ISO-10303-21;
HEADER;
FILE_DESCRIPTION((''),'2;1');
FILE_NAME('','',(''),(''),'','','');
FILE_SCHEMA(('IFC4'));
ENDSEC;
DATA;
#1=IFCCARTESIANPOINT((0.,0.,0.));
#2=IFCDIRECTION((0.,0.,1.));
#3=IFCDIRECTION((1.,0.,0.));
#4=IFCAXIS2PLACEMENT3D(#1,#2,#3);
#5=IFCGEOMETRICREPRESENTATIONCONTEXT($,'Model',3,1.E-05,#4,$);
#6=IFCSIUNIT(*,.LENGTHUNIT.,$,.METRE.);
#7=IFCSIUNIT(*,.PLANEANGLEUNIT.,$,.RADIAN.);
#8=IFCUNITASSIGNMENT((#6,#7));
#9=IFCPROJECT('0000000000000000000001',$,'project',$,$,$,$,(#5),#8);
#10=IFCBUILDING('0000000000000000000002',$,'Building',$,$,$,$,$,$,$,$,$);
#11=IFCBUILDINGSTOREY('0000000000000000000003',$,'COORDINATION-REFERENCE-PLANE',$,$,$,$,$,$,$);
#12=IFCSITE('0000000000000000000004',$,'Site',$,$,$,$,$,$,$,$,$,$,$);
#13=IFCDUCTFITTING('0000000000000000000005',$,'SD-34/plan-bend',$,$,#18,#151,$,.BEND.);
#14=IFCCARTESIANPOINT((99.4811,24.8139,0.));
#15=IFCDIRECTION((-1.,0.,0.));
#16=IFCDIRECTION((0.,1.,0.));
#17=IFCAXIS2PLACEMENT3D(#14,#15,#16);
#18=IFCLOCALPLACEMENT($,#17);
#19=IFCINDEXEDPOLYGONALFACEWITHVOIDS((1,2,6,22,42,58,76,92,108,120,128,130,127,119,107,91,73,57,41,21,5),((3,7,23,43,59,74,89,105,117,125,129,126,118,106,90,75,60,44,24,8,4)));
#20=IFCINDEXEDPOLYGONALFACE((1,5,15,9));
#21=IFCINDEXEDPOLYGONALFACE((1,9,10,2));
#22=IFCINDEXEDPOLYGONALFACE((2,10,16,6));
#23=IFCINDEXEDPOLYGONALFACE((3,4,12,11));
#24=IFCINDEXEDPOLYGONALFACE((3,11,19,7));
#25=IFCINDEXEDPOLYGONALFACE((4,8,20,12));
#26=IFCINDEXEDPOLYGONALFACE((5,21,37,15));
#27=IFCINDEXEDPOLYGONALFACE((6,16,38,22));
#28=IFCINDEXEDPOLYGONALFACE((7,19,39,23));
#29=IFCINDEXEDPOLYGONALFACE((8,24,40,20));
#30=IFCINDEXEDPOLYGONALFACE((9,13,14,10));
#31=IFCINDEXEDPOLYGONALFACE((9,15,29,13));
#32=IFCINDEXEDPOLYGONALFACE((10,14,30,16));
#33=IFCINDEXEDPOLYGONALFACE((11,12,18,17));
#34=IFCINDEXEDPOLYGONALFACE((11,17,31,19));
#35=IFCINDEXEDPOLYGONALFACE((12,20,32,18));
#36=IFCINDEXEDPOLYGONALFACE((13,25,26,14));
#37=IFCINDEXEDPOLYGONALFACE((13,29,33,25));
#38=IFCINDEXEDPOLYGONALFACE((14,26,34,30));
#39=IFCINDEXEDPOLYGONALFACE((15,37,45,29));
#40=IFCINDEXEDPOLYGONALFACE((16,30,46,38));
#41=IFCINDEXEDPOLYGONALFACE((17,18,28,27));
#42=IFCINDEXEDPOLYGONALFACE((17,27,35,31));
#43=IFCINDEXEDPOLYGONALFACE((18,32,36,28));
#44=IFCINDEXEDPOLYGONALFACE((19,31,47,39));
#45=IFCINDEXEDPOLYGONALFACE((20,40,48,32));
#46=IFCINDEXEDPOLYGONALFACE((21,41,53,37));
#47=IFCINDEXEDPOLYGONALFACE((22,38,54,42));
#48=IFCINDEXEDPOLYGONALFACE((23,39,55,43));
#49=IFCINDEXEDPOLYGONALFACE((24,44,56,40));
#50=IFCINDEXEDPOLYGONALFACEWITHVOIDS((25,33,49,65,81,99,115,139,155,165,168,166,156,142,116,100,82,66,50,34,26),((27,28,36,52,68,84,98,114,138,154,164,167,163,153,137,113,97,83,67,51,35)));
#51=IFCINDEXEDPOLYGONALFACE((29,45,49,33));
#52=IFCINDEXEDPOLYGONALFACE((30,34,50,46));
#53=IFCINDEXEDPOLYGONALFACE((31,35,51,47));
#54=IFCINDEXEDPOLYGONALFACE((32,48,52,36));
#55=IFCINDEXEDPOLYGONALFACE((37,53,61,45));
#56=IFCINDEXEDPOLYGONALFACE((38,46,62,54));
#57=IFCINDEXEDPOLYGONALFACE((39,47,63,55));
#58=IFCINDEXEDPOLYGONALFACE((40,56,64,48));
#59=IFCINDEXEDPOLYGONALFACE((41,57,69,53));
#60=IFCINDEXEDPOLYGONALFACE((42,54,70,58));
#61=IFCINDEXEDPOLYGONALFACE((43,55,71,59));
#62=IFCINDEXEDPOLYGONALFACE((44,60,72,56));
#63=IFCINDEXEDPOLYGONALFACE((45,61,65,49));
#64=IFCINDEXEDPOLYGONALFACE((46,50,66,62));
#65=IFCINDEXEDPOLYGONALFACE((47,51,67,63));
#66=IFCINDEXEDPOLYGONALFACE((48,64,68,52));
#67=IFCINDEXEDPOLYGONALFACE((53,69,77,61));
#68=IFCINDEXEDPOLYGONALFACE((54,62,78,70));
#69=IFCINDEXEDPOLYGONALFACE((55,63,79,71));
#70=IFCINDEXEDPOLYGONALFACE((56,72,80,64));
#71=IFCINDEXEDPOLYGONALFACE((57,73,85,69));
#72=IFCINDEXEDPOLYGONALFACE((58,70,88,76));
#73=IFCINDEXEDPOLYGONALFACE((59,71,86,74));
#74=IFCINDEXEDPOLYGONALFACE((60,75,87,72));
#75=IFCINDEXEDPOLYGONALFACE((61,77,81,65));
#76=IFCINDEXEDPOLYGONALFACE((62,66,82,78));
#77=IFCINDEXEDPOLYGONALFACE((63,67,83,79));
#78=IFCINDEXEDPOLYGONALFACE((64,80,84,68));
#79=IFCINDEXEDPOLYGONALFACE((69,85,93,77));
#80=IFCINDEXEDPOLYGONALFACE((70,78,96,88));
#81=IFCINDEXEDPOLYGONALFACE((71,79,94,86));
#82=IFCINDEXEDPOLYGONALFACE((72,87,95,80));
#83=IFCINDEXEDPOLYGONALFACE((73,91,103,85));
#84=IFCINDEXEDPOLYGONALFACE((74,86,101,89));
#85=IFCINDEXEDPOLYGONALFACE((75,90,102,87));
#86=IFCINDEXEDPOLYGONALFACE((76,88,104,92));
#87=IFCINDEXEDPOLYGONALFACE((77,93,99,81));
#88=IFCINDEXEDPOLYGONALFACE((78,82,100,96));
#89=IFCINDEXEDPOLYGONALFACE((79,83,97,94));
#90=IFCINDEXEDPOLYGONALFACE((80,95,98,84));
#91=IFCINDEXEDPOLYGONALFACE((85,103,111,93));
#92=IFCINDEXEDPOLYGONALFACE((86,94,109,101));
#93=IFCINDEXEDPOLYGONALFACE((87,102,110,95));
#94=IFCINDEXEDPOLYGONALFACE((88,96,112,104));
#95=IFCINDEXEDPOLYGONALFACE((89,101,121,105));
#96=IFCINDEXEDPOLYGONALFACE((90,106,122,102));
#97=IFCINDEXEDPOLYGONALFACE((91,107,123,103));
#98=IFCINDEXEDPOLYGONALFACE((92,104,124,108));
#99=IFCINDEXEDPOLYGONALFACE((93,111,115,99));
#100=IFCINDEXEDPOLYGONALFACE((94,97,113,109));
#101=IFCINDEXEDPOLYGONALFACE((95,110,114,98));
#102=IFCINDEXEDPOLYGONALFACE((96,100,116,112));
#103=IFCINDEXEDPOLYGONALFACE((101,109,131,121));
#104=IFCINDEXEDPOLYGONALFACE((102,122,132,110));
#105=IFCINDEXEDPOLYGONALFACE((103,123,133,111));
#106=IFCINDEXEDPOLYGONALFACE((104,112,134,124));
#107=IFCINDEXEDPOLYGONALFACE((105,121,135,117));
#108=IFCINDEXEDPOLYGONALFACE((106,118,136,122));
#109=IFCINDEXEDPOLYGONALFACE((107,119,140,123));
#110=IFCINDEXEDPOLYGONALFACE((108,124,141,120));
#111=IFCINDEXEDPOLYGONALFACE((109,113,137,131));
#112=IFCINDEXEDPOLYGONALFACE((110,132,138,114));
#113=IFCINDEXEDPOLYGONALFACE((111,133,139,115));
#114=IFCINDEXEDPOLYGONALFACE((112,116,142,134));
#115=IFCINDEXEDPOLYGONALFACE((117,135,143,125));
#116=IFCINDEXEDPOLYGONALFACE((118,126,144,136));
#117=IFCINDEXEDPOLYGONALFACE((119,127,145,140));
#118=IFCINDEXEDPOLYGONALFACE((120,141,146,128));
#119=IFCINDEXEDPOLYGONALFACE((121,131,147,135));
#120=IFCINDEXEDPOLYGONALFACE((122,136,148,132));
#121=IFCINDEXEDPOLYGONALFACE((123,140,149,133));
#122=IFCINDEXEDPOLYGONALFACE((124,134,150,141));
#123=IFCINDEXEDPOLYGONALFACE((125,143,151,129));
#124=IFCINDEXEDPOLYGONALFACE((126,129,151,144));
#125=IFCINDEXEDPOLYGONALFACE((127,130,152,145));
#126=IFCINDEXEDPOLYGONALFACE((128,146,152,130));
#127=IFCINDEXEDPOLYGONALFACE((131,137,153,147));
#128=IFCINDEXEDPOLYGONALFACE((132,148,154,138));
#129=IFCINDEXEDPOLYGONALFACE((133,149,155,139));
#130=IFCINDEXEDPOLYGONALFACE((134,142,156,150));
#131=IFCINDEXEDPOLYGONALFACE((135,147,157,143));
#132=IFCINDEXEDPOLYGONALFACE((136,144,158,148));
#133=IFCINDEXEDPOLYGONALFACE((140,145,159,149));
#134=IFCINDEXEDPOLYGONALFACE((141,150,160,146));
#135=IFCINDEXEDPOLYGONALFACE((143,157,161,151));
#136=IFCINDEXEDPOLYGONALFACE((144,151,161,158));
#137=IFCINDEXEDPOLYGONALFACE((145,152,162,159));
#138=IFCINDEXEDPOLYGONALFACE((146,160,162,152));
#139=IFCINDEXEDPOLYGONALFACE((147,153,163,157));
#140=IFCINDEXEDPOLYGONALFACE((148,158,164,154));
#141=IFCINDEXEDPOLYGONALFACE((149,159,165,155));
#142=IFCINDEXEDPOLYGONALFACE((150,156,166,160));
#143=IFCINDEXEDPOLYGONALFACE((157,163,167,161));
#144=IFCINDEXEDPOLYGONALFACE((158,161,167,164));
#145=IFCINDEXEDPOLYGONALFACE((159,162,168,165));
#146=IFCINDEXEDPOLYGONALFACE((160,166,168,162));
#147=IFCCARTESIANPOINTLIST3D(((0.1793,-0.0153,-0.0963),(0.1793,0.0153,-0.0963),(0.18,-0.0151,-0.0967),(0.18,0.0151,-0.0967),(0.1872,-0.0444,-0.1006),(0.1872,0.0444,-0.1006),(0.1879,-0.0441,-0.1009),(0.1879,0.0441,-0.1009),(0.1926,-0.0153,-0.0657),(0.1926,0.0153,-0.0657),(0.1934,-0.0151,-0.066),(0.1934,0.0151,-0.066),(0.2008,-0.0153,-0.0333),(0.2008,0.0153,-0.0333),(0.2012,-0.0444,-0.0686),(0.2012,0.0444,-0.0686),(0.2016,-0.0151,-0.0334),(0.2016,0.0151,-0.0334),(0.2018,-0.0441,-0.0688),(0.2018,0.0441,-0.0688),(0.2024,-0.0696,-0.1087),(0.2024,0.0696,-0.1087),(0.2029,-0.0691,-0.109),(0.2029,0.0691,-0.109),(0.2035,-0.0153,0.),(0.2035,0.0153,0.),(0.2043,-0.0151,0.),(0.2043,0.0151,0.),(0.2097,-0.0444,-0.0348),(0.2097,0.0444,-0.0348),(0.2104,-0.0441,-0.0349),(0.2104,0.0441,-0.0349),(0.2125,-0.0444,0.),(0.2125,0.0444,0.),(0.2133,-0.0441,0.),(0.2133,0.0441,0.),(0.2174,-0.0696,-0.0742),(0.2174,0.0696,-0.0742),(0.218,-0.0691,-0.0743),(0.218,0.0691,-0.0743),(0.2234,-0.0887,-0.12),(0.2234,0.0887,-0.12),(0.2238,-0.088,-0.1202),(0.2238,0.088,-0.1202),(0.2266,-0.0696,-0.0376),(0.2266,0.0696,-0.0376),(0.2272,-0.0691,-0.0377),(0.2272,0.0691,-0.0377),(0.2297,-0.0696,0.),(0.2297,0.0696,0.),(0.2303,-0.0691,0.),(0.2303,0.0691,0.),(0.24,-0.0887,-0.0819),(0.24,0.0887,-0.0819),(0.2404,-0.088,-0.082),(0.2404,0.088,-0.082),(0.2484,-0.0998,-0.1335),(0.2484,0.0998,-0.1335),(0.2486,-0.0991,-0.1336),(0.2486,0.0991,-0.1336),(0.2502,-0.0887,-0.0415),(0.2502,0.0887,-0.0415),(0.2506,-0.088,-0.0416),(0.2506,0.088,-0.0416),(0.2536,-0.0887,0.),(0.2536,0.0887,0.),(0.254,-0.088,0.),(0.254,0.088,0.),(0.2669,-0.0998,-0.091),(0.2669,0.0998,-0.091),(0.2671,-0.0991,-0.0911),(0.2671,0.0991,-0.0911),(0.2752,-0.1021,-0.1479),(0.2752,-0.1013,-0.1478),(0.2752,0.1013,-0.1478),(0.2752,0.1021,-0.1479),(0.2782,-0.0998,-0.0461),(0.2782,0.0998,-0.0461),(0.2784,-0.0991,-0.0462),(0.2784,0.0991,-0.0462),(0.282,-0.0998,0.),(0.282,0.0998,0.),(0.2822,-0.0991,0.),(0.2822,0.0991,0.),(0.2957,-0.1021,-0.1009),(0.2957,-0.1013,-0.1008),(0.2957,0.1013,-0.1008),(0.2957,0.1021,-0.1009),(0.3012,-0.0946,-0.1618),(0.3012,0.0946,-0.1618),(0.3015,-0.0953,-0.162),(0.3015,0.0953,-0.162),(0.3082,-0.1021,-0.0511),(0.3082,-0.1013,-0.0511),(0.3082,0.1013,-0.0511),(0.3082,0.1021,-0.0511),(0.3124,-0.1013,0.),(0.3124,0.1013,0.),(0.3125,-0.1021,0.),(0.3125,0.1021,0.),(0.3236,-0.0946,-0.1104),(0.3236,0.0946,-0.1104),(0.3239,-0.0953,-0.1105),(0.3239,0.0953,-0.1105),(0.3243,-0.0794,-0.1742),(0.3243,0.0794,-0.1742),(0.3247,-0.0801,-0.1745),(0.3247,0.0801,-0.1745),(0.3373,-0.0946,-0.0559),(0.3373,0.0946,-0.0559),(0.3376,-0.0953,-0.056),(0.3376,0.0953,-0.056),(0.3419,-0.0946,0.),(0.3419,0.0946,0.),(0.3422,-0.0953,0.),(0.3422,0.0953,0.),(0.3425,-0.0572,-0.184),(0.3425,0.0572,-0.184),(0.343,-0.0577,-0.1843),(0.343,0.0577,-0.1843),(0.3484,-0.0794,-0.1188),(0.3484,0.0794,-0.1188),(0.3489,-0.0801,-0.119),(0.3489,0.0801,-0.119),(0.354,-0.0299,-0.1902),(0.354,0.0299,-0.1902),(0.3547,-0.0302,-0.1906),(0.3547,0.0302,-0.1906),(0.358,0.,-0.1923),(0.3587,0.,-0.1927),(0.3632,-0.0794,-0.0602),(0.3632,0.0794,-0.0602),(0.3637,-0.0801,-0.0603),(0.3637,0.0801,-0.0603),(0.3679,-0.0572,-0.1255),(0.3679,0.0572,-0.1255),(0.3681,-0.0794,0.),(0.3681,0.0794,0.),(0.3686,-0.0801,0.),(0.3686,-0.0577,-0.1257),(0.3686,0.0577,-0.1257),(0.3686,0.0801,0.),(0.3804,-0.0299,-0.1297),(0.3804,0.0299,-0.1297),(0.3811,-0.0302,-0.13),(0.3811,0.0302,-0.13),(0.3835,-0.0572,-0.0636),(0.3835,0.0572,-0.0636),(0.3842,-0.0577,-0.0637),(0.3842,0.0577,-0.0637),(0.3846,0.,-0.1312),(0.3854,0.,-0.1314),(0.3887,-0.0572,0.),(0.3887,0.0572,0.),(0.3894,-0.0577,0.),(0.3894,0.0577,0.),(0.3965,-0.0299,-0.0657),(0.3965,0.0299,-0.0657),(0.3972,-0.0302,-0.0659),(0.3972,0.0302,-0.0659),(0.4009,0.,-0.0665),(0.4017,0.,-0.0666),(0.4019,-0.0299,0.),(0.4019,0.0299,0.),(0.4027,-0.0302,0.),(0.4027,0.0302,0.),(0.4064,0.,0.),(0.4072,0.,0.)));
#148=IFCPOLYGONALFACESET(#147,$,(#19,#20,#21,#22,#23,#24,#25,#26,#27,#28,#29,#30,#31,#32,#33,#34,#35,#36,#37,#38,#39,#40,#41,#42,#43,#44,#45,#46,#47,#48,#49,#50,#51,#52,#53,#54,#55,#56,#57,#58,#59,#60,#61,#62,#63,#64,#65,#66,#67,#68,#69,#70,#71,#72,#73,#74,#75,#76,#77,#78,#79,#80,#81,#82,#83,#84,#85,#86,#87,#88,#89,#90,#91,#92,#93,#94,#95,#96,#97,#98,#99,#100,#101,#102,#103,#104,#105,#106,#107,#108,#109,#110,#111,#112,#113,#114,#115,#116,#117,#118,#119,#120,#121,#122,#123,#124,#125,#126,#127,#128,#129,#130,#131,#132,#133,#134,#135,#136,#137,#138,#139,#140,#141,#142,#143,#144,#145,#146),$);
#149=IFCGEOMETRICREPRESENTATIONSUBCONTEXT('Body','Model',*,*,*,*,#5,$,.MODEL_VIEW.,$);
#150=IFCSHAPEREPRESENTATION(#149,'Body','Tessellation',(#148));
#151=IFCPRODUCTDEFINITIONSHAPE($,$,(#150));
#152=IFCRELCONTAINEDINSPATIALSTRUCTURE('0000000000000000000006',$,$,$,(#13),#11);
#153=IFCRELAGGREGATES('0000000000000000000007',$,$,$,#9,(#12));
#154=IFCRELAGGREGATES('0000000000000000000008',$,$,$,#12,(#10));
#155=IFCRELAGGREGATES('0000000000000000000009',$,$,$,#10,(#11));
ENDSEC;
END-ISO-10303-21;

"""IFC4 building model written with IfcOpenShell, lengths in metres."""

from ifc_helpers import new_model, entity, si_unit, frame, origin_with_axes, place, context, subcontext, project, spatial, element, save


model = new_model("IFC4")

# Units and contexts
model_context = context("Model", 3, precision=1e-05, world=origin_with_axes())
body_context_1 = subcontext(model_context, "Body", "Model", "MODEL_VIEW")
ifc_project = project(units=[si_unit("LENGTHUNIT", "METRE"), si_unit("PLANEANGLEUNIT", "RADIAN")], contexts=[model_context])

# Site, building, storey
site = spatial("IfcSite", under=ifc_project, Name="Site")
building = spatial("IfcBuilding", under=site, Name="Building")
storey = spatial("IfcBuildingStorey", under=building, Name="COORDINATION-REFERENCE-PLANE")

# Duct fitting
duct_fitting_1_placement = place(None, frame((99.4811, 24.8139, 0.0), z_axis=(-1.0, 0.0, 0.0), x_axis=(0.0, 1.0, 0.0)))
element("IfcDuctFitting", 1, at=duct_fitting_1_placement, inside=storey, Name="SD-34/plan-bend", PredefinedType="BEND", context=body_context_1, shape_type="SweptSolid", body=[
    entity("IfcRevolvedAreaSolid", entity("IfcCircleHollowProfileDef", "AREA", None, entity("IfcAxis2Placement2D", entity("IfcCartesianPoint", [0.3048, 0.0])), 0.1024, 0.0008), entity("IfcAxis2Placement3D", entity("IfcCartesianPoint", [0.0, 0.0, 0.0]), entity("IfcDirection", [0.0, 0.0, 1.0]), entity("IfcDirection", [1.0, 0.0, 0.0])), entity("IfcAxis1Placement", entity("IfcCartesianPoint", [0.0, 0.0, 0.0]), entity("IfcDirection", [0.0, 1.0, 0.0])), 0.49301),
])

save(model, "model.ifc")
